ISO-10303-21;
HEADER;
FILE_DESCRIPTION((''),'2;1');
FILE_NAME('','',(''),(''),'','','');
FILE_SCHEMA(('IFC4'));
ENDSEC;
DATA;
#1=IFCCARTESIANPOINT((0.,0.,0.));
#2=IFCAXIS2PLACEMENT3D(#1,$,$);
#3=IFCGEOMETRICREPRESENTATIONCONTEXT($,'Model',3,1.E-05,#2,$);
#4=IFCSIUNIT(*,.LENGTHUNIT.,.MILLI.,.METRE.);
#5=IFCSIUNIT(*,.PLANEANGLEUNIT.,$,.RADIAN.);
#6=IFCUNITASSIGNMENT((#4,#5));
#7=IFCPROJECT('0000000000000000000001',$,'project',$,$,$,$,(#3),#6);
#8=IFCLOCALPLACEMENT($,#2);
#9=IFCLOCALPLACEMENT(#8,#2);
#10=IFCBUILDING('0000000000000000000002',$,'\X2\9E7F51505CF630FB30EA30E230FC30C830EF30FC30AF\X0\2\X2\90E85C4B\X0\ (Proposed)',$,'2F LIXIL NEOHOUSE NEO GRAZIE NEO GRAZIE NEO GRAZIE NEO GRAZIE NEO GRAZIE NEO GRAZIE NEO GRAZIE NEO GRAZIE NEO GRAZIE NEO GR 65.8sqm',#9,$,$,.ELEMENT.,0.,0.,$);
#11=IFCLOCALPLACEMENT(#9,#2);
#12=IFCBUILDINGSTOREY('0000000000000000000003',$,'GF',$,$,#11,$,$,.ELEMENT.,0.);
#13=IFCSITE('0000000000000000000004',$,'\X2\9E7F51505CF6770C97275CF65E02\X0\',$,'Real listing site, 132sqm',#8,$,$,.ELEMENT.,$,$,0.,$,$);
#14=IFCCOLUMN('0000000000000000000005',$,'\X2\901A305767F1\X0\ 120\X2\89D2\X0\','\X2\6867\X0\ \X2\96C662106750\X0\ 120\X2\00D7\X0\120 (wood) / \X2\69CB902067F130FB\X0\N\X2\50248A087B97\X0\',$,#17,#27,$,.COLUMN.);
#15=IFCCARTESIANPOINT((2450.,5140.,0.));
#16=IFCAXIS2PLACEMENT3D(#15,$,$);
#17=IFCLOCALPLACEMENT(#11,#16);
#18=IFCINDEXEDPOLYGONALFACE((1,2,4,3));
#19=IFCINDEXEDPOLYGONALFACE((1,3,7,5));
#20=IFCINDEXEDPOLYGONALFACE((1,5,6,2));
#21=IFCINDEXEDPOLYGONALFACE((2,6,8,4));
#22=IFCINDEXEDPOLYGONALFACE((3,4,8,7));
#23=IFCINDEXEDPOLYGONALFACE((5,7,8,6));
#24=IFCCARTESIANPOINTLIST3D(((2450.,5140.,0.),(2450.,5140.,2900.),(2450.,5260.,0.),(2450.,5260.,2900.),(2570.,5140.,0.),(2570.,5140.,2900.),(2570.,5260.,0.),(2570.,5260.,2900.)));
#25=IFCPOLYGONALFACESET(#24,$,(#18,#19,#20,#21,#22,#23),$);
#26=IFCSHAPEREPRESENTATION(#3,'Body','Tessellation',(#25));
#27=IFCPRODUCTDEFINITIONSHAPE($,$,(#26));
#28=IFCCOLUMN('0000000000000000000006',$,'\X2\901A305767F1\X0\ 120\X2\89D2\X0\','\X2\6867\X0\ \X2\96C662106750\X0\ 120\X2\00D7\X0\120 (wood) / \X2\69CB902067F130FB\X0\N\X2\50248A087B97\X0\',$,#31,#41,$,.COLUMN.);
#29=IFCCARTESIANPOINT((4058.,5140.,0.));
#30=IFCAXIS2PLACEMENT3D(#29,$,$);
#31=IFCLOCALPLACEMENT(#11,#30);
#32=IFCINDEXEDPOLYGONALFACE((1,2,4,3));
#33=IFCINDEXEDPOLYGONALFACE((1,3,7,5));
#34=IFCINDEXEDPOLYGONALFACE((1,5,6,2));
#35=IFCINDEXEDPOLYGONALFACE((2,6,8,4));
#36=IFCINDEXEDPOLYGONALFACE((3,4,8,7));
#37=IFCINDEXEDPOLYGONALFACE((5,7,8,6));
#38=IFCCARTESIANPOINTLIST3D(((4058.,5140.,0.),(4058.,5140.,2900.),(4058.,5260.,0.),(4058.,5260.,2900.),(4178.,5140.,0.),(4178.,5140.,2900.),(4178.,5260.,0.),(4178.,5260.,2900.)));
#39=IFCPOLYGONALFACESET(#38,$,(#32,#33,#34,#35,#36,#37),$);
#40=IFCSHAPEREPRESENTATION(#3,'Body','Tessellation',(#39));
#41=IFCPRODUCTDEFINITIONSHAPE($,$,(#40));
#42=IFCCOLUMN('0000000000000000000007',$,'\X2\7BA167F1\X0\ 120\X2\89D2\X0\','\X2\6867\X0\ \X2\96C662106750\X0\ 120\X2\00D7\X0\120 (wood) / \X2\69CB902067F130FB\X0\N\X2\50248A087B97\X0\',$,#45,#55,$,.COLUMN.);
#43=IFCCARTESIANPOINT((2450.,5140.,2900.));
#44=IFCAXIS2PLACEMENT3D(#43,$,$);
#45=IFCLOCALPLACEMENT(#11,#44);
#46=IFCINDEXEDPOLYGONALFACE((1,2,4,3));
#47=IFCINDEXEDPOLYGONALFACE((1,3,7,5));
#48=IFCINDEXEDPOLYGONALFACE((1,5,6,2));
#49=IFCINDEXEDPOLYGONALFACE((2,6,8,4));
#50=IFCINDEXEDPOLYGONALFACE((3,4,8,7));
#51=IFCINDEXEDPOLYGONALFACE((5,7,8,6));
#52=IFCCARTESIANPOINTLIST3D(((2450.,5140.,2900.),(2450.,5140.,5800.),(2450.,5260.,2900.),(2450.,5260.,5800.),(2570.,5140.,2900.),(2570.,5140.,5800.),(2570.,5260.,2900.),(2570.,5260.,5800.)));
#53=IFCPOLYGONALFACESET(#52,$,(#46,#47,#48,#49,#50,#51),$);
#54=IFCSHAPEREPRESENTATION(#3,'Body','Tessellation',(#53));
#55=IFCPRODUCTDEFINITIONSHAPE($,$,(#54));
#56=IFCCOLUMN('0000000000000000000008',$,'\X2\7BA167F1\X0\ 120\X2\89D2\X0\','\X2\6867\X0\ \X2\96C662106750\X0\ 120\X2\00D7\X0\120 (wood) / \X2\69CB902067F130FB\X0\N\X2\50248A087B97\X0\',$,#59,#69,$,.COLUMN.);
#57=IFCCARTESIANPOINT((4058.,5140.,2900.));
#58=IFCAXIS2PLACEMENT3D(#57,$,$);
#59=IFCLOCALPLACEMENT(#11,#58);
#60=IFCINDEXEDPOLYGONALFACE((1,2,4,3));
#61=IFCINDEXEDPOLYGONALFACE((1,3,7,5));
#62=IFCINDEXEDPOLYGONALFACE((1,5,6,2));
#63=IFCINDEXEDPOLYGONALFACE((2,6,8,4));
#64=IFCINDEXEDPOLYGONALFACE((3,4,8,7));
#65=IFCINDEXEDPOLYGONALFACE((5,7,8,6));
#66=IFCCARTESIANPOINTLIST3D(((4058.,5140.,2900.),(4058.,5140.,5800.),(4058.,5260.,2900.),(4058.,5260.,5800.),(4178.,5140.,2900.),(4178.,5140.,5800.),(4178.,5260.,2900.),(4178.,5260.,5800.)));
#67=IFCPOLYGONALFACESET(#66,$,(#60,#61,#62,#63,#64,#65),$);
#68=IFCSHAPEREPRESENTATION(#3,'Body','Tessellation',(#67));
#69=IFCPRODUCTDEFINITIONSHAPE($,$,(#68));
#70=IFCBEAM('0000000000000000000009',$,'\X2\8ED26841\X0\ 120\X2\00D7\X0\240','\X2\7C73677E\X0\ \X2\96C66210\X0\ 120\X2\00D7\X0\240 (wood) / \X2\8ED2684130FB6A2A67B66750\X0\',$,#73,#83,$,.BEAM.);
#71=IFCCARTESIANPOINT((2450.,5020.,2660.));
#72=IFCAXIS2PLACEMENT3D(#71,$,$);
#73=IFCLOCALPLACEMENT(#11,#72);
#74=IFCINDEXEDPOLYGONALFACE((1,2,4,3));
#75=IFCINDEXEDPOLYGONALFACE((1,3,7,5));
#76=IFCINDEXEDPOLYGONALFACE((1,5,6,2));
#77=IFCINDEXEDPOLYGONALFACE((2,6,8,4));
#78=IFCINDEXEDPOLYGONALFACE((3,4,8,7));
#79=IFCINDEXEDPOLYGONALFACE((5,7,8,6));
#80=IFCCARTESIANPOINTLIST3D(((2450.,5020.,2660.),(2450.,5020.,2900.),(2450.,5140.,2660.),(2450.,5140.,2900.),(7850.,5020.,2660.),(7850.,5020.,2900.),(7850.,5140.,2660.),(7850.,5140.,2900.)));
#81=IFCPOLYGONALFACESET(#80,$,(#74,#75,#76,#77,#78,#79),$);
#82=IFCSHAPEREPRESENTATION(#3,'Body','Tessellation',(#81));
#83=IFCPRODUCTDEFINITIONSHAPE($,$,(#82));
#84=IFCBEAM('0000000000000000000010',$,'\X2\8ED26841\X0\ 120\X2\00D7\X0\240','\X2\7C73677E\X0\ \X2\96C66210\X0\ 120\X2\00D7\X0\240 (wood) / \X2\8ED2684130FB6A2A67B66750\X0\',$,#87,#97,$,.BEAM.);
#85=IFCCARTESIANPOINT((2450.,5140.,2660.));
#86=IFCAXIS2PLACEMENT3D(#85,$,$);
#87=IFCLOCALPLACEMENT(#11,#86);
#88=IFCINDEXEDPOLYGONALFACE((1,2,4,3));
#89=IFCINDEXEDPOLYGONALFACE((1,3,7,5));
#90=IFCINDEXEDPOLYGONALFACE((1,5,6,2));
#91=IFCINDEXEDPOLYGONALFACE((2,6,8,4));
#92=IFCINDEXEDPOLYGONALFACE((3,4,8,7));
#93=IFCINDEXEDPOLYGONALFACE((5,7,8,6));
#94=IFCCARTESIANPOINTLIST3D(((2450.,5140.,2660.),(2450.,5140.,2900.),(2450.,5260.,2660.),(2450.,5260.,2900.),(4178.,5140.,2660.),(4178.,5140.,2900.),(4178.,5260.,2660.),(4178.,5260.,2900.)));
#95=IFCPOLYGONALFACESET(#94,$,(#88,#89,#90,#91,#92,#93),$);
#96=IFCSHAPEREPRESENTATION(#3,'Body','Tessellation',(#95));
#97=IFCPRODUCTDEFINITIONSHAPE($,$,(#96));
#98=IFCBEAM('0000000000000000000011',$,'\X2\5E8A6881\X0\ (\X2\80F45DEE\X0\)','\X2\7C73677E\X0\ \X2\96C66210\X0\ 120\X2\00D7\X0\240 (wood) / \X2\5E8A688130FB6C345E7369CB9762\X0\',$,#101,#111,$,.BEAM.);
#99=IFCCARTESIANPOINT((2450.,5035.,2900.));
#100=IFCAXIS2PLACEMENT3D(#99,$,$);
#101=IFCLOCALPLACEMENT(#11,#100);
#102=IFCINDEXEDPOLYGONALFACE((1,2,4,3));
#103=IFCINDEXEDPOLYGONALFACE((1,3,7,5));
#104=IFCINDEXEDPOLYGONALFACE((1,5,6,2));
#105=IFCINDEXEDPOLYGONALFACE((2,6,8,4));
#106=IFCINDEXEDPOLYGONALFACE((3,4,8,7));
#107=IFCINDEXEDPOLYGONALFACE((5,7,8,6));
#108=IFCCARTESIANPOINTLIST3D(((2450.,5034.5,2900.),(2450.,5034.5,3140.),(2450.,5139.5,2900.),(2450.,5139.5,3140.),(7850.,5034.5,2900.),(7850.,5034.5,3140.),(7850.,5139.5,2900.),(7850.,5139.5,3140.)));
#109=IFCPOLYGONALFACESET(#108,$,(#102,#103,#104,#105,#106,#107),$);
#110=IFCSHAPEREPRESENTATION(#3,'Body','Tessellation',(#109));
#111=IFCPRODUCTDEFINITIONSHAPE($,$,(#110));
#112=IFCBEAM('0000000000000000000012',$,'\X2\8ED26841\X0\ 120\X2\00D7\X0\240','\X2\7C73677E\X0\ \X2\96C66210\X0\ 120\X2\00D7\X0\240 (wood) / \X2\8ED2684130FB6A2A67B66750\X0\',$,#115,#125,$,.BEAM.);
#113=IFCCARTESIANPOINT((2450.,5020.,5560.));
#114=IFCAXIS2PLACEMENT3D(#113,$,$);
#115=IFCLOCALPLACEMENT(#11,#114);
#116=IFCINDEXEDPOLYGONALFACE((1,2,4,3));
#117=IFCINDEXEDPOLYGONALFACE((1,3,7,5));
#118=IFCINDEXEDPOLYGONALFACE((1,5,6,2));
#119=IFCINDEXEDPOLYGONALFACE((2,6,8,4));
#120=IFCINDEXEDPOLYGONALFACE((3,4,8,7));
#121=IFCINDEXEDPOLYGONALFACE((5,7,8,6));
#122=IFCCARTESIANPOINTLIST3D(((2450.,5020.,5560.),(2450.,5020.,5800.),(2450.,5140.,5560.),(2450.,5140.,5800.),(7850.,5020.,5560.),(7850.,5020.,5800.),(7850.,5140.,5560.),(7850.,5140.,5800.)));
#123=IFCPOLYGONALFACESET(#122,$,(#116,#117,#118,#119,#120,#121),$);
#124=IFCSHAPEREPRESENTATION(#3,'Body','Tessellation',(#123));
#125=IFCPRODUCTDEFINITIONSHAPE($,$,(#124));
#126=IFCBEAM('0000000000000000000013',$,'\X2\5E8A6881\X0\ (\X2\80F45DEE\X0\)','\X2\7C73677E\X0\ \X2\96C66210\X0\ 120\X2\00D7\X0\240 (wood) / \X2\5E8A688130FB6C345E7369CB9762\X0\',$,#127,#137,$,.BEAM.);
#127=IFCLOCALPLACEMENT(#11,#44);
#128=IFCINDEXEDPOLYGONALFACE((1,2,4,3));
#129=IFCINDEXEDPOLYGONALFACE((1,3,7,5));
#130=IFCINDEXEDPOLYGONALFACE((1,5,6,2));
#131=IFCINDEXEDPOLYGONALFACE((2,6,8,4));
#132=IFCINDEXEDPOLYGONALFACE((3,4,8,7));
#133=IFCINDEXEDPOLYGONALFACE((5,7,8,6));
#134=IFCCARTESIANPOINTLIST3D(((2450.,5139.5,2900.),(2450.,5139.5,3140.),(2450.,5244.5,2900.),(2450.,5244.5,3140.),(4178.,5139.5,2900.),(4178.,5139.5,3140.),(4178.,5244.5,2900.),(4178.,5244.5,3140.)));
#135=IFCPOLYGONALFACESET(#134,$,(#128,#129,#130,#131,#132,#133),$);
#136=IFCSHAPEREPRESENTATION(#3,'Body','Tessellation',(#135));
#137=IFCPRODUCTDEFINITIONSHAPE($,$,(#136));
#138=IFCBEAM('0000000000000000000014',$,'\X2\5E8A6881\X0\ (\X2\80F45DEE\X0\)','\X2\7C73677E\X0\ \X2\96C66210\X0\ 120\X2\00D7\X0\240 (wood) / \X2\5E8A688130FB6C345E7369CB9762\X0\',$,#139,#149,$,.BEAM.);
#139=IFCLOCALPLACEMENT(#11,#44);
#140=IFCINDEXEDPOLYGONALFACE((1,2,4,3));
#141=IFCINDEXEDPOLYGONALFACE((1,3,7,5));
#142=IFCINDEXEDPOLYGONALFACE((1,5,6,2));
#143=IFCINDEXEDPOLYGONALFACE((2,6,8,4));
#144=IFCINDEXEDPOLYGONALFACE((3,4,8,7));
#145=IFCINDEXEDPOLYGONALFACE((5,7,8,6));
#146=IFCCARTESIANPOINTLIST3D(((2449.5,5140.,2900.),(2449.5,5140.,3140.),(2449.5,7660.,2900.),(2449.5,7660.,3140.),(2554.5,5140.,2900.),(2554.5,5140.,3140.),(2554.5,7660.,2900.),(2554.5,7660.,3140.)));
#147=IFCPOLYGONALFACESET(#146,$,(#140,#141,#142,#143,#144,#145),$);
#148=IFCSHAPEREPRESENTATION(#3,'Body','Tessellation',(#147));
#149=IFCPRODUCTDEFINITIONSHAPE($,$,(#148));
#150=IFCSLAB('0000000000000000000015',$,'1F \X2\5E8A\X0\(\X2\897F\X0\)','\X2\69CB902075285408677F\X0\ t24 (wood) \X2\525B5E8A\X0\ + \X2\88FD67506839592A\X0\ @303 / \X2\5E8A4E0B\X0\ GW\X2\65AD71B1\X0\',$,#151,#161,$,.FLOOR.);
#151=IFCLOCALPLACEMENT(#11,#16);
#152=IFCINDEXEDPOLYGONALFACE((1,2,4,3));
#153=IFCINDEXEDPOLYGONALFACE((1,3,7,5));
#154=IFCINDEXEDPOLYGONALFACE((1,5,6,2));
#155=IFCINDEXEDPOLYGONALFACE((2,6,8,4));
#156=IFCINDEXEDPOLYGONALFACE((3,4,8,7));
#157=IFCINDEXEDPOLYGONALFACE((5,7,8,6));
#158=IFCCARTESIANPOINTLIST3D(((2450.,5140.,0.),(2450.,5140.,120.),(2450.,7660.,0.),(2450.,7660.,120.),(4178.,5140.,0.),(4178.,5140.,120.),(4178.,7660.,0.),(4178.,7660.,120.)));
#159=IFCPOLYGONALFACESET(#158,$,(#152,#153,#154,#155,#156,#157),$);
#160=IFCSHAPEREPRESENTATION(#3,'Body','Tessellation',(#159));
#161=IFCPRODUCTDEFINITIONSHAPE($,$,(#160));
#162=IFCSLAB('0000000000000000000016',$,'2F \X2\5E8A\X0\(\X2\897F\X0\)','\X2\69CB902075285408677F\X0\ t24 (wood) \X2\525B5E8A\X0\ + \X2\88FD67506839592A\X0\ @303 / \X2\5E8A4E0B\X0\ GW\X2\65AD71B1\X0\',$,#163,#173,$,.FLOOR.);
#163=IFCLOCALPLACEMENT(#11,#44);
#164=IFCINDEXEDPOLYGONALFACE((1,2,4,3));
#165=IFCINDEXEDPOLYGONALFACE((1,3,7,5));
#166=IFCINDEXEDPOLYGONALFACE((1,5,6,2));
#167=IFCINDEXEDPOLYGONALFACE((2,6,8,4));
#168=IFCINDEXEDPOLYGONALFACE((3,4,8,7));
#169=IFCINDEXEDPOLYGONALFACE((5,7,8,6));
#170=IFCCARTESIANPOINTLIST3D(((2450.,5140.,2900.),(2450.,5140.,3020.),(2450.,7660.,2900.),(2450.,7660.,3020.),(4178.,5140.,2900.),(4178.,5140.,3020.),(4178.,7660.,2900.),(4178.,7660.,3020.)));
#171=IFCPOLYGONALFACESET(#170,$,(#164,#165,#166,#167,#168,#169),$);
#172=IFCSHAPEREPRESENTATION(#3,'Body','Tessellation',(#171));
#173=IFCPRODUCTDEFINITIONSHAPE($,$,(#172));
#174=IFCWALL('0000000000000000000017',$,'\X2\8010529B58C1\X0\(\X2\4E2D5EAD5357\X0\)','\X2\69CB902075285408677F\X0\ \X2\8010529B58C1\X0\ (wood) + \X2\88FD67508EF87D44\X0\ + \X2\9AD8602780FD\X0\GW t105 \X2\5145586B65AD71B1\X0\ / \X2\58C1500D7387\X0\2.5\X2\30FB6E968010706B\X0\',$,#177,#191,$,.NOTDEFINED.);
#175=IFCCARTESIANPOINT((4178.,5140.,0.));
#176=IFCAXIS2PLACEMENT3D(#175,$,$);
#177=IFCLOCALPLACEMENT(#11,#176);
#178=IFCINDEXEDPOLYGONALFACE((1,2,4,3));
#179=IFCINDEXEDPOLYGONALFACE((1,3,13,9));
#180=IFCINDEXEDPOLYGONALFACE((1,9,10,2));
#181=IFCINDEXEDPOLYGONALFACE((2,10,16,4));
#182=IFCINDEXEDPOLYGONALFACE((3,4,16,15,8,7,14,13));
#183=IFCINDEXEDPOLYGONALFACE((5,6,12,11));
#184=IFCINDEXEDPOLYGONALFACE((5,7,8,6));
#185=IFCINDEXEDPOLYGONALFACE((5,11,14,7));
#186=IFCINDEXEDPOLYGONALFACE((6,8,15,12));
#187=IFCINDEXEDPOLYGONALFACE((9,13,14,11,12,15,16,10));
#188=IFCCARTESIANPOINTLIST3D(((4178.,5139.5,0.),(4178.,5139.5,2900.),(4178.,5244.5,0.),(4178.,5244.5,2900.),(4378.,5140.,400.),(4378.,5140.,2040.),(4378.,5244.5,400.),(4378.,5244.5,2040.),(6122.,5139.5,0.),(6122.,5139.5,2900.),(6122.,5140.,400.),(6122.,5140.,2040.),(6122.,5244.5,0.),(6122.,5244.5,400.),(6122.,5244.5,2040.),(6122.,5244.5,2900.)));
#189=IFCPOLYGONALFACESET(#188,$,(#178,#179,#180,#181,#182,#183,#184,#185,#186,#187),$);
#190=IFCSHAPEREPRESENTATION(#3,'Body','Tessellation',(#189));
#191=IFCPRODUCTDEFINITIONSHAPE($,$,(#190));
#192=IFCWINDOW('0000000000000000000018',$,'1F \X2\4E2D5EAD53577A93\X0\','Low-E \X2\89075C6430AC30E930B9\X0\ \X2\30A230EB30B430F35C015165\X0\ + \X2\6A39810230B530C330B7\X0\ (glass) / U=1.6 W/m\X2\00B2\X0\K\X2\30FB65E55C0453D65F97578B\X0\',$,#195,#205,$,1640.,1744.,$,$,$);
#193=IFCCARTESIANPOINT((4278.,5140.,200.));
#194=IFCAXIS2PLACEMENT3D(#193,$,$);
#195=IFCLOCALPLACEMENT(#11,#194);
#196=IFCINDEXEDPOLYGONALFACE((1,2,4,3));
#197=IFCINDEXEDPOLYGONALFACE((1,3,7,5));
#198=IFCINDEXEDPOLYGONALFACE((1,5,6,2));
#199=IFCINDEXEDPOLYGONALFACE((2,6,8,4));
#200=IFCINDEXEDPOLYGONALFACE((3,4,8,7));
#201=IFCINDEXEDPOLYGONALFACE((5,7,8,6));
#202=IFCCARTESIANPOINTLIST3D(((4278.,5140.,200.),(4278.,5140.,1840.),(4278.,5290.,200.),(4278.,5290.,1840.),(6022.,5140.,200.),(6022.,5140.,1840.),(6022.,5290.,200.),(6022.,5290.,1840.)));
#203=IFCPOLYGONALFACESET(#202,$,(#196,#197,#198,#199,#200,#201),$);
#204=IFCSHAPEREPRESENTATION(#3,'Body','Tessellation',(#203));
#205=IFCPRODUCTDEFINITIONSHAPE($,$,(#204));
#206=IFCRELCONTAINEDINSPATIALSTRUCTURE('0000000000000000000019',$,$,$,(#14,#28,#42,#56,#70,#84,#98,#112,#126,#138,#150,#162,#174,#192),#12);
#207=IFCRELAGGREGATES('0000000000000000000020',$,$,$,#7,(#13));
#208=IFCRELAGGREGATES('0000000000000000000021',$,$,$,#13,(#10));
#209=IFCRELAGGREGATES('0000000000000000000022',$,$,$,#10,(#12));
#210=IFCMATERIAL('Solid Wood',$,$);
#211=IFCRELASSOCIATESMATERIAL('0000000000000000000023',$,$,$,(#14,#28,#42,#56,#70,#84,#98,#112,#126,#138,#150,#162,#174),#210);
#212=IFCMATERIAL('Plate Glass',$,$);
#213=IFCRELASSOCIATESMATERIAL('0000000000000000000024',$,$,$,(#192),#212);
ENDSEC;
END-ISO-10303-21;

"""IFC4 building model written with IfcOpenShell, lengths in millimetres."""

from ifc_helpers import new_model, si_unit, frame, frame_2d, origin, place, context, project, spatial, rectangle, extrude, material, element, fill, save


model = new_model("IFC4")

# Units and contexts
model_context = context("Model", 3, precision=1e-05, world=origin())
ifc_project = project(units=[si_unit("LENGTHUNIT", "METRE", prefix="MILLI"), si_unit("PLANEANGLEUNIT", "RADIAN")], contexts=[model_context])

# Site, building, storey
site_placement = place(None, origin())
site = spatial("IfcSite", under=ifc_project, at=site_placement, Name="鹿児島県霧島市", ObjectType="Real listing site, 132sqm", CompositionType="ELEMENT", RefElevation=0.0)
building_placement = place(site_placement, origin())
building = spatial("IfcBuilding", under=site, at=building_placement, Name="鹿児島・リモートワーク2部屋 (Proposed)", ObjectType="2F LIXIL NEOHOUSE NEO GRAZIE NEO GRAZIE NEO GRAZIE NEO GRAZIE NEO GRAZIE NEO GRAZIE NEO GRAZIE NEO GRAZIE NEO GRAZIE NEO GR 65.8sqm", CompositionType="ELEMENT", ElevationOfRefHeight=0.0, ElevationOfTerrain=0.0)
storey_placement = place(building_placement, origin())
storey = spatial("IfcBuildingStorey", under=building, at=storey_placement, Name="GF", CompositionType="ELEMENT", Elevation=0.0)

# Columns
ifc_material_1 = material(Name="Solid Wood")
column_1_placement = place(storey_placement, frame((2450.0, 5140.0, 0.0)))
element("IfcColumn", 1, at=column_1_placement, inside=storey, material=ifc_material_1, Name="通し柱 120角", Description="桧 集成材 120×120 (wood) / 構造柱・N値計算", PredefinedType="COLUMN", context=model_context, shape_type="SweptSolid", body=[
    extrude(rectangle(XDim=120.0, YDim=120.0, at=frame_2d((60.0, 60.0))), frame((2450.0, 5140.0, 0.0)), (0.0, 0.0, 1.0), 2900.0),
])
column_2_placement = place(storey_placement, frame((4058.0, 5140.0, 0.0)))
element("IfcColumn", 2, at=column_2_placement, inside=storey, material=ifc_material_1, Name="通し柱 120角", Description="桧 集成材 120×120 (wood) / 構造柱・N値計算", PredefinedType="COLUMN", context=model_context, shape_type="SweptSolid", body=[
    extrude(rectangle(XDim=120.0, YDim=120.0, at=frame_2d((60.0, 60.0))), frame((4058.0, 5140.0, 0.0)), (0.0, 0.0, 1.0), 2900.0),
])
column_3_placement = place(storey_placement, frame((2450.0, 5140.0, 2900.0)))
element("IfcColumn", 3, at=column_3_placement, inside=storey, material=ifc_material_1, Name="管柱 120角", Description="桧 集成材 120×120 (wood) / 構造柱・N値計算", PredefinedType="COLUMN", context=model_context, shape_type="SweptSolid", body=[
    extrude(rectangle(XDim=120.0, YDim=120.0, at=frame_2d((60.0, 60.0))), frame((2450.0, 5140.0, 2900.0)), (0.0, 0.0, 1.0), 2900.0),
])
column_4_placement = place(storey_placement, frame((4058.0, 5140.0, 2900.0)))
element("IfcColumn", 4, at=column_4_placement, inside=storey, material=ifc_material_1, Name="管柱 120角", Description="桧 集成材 120×120 (wood) / 構造柱・N値計算", PredefinedType="COLUMN", context=model_context, shape_type="SweptSolid", body=[
    extrude(rectangle(XDim=120.0, YDim=120.0, at=frame_2d((60.0, 60.0))), frame((4058.0, 5140.0, 2900.0)), (0.0, 0.0, 1.0), 2900.0),
])

# Beams
beam_1_placement = place(storey_placement, frame((2450.0, 5020.0, 2660.0)))
element("IfcBeam", 5, at=beam_1_placement, inside=storey, material=ifc_material_1, Name="軒桁 120×240", Description="米松 集成 120×240 (wood) / 軒桁・横架材", PredefinedType="BEAM", context=model_context, shape_type="SweptSolid", body=[
    extrude(rectangle(XDim=5400.0, YDim=120.0, at=frame_2d((2700.0, 60.0))), frame((2450.0, 5020.0, 2660.0)), (0.0, 0.0, 1.0), 240.0),
])
beam_2_placement = place(storey_placement, frame((2450.0, 5140.0, 2660.0)))
element("IfcBeam", 6, at=beam_2_placement, inside=storey, material=ifc_material_1, Name="軒桁 120×240", Description="米松 集成 120×240 (wood) / 軒桁・横架材", PredefinedType="BEAM", context=model_context, shape_type="SweptSolid", body=[
    extrude(rectangle(XDim=1728.0, YDim=120.0, at=frame_2d((864.0, 60.0))), frame((2450.0, 5140.0, 2660.0)), (0.0, 0.0, 1.0), 240.0),
])
beam_3_placement = place(storey_placement, frame((2450.0, 5035.0, 2900.0)))
element("IfcBeam", 7, at=beam_3_placement, inside=storey, material=ifc_material_1, Name="床梁 (胴差)", Description="米松 集成 120×240 (wood) / 床梁・水平構面", PredefinedType="BEAM", context=model_context, shape_type="SweptSolid", body=[
    extrude(rectangle(XDim=5400.0, YDim=105.0, at=frame_2d((2700.0, 52.0))), frame((2450.0, 5035.0, 2900.0)), (0.0, 0.0, 1.0), 240.0),
])
beam_4_placement = place(storey_placement, frame((2450.0, 5020.0, 5560.0)))
element("IfcBeam", 8, at=beam_4_placement, inside=storey, material=ifc_material_1, Name="軒桁 120×240", Description="米松 集成 120×240 (wood) / 軒桁・横架材", PredefinedType="BEAM", context=model_context, shape_type="SweptSolid", body=[
    extrude(rectangle(XDim=5400.0, YDim=120.0, at=frame_2d((2700.0, 60.0))), frame((2450.0, 5020.0, 5560.0)), (0.0, 0.0, 1.0), 240.0),
])
beam_5_placement = place(storey_placement, frame((2450.0, 5140.0, 2900.0)))
element("IfcBeam", 9, at=beam_5_placement, inside=storey, material=ifc_material_1, Name="床梁 (胴差)", Description="米松 集成 120×240 (wood) / 床梁・水平構面", PredefinedType="BEAM", context=model_context, shape_type="SweptSolid", body=[
    extrude(rectangle(XDim=1728.0, YDim=105.0, at=frame_2d((864.0, 52.0))), frame((2450.0, 5140.0, 2900.0)), (0.0, 0.0, 1.0), 240.0),
])
beam_6_placement = place(storey_placement, frame((2450.0, 5140.0, 2900.0)))
element("IfcBeam", 10, at=beam_6_placement, inside=storey, material=ifc_material_1, Name="床梁 (胴差)", Description="米松 集成 120×240 (wood) / 床梁・水平構面", PredefinedType="BEAM", context=model_context, shape_type="SweptSolid", body=[
    extrude(rectangle(XDim=105.0, YDim=2520.0, at=frame_2d((52.0, 1260.0))), frame((2450.0, 5140.0, 2900.0)), (0.0, 0.0, 1.0), 240.0),
])

# Slabs
slab_1_placement = place(storey_placement, frame((2450.0, 5140.0, 0.0)))
element("IfcSlab", 11, at=slab_1_placement, inside=storey, material=ifc_material_1, Name="1F 床(西)", Description="構造用合板 t24 (wood) 剛床 + 製材根太 @303 / 床下 GW断熱", PredefinedType="FLOOR", context=model_context, shape_type="SweptSolid", body=[
    extrude(rectangle(XDim=1728.0, YDim=2520.0, at=frame_2d((864.0, 1260.0))), frame((2450.0, 5140.0, 0.0)), (0.0, 0.0, 1.0), 120.0),
])
slab_2_placement = place(storey_placement, frame((2450.0, 5140.0, 2900.0)))
element("IfcSlab", 12, at=slab_2_placement, inside=storey, material=ifc_material_1, Name="2F 床(西)", Description="構造用合板 t24 (wood) 剛床 + 製材根太 @303 / 床下 GW断熱", PredefinedType="FLOOR", context=model_context, shape_type="SweptSolid", body=[
    extrude(rectangle(XDim=1728.0, YDim=2520.0, at=frame_2d((864.0, 1260.0))), frame((2450.0, 5140.0, 2900.0)), (0.0, 0.0, 1.0), 120.0),
])

# Wall, opening, window
wall_placement = place(storey_placement, frame((4178.0, 5140.0, 0.0)))
wall = element("IfcWall", 13, at=wall_placement, inside=storey, material=ifc_material_1, Name="耐力壁(中庭南)", Description="構造用合板 耐力壁 (wood) + 製材軸組 + 高性能GW t105 充填断熱 / 壁倍率2.5・準耐火", PredefinedType="NOTDEFINED", context=model_context, shape_type="SweptSolid", body=[
    extrude(rectangle(XDim=1944.0, YDim=105.0, at=frame_2d((972.0, 52.0))), frame((4178.0, 5140.0, 0.0)), (0.0, 0.0, 1.0), 2900.0),
])
opening_placement = place(storey_placement, frame((4278.0, 5140.0, 200.0)))
opening = element("IfcOpeningElement", 14, at=opening_placement, cuts=wall, PredefinedType="NOTDEFINED", context=model_context, shape_type="SweptSolid", body=[
    extrude(rectangle(XDim=1744.0, YDim=150.0, at=frame_2d((872.0, 75.0))), frame((4278.0, 5140.0, 200.0)), (0.0, 0.0, 1.0), 1640.0),
])
ifc_material_2 = material(Name="Plate Glass")
window_1_placement = place(storey_placement, frame((4278.0, 5140.0, 200.0)))
window_1 = element("IfcWindow", 15, at=window_1_placement, inside=storey, material=ifc_material_2, Name="1F 中庭南窓", Description="Low-E 複層ガラス アルゴン封入 + 樹脂サッシ (glass) / U=1.6 W/m²K・日射取得型", OverallHeight=1640.0, OverallWidth=1744.0, context=model_context, shape_type="SweptSolid", body=[
    extrude(rectangle(XDim=1744.0, YDim=150.0, at=frame_2d((872.0, 75.0))), frame((4278.0, 5140.0, 200.0)), (0.0, 0.0, 1.0), 1640.0),
])
fill(opening, window_1)

save(model, "model.ifc")
